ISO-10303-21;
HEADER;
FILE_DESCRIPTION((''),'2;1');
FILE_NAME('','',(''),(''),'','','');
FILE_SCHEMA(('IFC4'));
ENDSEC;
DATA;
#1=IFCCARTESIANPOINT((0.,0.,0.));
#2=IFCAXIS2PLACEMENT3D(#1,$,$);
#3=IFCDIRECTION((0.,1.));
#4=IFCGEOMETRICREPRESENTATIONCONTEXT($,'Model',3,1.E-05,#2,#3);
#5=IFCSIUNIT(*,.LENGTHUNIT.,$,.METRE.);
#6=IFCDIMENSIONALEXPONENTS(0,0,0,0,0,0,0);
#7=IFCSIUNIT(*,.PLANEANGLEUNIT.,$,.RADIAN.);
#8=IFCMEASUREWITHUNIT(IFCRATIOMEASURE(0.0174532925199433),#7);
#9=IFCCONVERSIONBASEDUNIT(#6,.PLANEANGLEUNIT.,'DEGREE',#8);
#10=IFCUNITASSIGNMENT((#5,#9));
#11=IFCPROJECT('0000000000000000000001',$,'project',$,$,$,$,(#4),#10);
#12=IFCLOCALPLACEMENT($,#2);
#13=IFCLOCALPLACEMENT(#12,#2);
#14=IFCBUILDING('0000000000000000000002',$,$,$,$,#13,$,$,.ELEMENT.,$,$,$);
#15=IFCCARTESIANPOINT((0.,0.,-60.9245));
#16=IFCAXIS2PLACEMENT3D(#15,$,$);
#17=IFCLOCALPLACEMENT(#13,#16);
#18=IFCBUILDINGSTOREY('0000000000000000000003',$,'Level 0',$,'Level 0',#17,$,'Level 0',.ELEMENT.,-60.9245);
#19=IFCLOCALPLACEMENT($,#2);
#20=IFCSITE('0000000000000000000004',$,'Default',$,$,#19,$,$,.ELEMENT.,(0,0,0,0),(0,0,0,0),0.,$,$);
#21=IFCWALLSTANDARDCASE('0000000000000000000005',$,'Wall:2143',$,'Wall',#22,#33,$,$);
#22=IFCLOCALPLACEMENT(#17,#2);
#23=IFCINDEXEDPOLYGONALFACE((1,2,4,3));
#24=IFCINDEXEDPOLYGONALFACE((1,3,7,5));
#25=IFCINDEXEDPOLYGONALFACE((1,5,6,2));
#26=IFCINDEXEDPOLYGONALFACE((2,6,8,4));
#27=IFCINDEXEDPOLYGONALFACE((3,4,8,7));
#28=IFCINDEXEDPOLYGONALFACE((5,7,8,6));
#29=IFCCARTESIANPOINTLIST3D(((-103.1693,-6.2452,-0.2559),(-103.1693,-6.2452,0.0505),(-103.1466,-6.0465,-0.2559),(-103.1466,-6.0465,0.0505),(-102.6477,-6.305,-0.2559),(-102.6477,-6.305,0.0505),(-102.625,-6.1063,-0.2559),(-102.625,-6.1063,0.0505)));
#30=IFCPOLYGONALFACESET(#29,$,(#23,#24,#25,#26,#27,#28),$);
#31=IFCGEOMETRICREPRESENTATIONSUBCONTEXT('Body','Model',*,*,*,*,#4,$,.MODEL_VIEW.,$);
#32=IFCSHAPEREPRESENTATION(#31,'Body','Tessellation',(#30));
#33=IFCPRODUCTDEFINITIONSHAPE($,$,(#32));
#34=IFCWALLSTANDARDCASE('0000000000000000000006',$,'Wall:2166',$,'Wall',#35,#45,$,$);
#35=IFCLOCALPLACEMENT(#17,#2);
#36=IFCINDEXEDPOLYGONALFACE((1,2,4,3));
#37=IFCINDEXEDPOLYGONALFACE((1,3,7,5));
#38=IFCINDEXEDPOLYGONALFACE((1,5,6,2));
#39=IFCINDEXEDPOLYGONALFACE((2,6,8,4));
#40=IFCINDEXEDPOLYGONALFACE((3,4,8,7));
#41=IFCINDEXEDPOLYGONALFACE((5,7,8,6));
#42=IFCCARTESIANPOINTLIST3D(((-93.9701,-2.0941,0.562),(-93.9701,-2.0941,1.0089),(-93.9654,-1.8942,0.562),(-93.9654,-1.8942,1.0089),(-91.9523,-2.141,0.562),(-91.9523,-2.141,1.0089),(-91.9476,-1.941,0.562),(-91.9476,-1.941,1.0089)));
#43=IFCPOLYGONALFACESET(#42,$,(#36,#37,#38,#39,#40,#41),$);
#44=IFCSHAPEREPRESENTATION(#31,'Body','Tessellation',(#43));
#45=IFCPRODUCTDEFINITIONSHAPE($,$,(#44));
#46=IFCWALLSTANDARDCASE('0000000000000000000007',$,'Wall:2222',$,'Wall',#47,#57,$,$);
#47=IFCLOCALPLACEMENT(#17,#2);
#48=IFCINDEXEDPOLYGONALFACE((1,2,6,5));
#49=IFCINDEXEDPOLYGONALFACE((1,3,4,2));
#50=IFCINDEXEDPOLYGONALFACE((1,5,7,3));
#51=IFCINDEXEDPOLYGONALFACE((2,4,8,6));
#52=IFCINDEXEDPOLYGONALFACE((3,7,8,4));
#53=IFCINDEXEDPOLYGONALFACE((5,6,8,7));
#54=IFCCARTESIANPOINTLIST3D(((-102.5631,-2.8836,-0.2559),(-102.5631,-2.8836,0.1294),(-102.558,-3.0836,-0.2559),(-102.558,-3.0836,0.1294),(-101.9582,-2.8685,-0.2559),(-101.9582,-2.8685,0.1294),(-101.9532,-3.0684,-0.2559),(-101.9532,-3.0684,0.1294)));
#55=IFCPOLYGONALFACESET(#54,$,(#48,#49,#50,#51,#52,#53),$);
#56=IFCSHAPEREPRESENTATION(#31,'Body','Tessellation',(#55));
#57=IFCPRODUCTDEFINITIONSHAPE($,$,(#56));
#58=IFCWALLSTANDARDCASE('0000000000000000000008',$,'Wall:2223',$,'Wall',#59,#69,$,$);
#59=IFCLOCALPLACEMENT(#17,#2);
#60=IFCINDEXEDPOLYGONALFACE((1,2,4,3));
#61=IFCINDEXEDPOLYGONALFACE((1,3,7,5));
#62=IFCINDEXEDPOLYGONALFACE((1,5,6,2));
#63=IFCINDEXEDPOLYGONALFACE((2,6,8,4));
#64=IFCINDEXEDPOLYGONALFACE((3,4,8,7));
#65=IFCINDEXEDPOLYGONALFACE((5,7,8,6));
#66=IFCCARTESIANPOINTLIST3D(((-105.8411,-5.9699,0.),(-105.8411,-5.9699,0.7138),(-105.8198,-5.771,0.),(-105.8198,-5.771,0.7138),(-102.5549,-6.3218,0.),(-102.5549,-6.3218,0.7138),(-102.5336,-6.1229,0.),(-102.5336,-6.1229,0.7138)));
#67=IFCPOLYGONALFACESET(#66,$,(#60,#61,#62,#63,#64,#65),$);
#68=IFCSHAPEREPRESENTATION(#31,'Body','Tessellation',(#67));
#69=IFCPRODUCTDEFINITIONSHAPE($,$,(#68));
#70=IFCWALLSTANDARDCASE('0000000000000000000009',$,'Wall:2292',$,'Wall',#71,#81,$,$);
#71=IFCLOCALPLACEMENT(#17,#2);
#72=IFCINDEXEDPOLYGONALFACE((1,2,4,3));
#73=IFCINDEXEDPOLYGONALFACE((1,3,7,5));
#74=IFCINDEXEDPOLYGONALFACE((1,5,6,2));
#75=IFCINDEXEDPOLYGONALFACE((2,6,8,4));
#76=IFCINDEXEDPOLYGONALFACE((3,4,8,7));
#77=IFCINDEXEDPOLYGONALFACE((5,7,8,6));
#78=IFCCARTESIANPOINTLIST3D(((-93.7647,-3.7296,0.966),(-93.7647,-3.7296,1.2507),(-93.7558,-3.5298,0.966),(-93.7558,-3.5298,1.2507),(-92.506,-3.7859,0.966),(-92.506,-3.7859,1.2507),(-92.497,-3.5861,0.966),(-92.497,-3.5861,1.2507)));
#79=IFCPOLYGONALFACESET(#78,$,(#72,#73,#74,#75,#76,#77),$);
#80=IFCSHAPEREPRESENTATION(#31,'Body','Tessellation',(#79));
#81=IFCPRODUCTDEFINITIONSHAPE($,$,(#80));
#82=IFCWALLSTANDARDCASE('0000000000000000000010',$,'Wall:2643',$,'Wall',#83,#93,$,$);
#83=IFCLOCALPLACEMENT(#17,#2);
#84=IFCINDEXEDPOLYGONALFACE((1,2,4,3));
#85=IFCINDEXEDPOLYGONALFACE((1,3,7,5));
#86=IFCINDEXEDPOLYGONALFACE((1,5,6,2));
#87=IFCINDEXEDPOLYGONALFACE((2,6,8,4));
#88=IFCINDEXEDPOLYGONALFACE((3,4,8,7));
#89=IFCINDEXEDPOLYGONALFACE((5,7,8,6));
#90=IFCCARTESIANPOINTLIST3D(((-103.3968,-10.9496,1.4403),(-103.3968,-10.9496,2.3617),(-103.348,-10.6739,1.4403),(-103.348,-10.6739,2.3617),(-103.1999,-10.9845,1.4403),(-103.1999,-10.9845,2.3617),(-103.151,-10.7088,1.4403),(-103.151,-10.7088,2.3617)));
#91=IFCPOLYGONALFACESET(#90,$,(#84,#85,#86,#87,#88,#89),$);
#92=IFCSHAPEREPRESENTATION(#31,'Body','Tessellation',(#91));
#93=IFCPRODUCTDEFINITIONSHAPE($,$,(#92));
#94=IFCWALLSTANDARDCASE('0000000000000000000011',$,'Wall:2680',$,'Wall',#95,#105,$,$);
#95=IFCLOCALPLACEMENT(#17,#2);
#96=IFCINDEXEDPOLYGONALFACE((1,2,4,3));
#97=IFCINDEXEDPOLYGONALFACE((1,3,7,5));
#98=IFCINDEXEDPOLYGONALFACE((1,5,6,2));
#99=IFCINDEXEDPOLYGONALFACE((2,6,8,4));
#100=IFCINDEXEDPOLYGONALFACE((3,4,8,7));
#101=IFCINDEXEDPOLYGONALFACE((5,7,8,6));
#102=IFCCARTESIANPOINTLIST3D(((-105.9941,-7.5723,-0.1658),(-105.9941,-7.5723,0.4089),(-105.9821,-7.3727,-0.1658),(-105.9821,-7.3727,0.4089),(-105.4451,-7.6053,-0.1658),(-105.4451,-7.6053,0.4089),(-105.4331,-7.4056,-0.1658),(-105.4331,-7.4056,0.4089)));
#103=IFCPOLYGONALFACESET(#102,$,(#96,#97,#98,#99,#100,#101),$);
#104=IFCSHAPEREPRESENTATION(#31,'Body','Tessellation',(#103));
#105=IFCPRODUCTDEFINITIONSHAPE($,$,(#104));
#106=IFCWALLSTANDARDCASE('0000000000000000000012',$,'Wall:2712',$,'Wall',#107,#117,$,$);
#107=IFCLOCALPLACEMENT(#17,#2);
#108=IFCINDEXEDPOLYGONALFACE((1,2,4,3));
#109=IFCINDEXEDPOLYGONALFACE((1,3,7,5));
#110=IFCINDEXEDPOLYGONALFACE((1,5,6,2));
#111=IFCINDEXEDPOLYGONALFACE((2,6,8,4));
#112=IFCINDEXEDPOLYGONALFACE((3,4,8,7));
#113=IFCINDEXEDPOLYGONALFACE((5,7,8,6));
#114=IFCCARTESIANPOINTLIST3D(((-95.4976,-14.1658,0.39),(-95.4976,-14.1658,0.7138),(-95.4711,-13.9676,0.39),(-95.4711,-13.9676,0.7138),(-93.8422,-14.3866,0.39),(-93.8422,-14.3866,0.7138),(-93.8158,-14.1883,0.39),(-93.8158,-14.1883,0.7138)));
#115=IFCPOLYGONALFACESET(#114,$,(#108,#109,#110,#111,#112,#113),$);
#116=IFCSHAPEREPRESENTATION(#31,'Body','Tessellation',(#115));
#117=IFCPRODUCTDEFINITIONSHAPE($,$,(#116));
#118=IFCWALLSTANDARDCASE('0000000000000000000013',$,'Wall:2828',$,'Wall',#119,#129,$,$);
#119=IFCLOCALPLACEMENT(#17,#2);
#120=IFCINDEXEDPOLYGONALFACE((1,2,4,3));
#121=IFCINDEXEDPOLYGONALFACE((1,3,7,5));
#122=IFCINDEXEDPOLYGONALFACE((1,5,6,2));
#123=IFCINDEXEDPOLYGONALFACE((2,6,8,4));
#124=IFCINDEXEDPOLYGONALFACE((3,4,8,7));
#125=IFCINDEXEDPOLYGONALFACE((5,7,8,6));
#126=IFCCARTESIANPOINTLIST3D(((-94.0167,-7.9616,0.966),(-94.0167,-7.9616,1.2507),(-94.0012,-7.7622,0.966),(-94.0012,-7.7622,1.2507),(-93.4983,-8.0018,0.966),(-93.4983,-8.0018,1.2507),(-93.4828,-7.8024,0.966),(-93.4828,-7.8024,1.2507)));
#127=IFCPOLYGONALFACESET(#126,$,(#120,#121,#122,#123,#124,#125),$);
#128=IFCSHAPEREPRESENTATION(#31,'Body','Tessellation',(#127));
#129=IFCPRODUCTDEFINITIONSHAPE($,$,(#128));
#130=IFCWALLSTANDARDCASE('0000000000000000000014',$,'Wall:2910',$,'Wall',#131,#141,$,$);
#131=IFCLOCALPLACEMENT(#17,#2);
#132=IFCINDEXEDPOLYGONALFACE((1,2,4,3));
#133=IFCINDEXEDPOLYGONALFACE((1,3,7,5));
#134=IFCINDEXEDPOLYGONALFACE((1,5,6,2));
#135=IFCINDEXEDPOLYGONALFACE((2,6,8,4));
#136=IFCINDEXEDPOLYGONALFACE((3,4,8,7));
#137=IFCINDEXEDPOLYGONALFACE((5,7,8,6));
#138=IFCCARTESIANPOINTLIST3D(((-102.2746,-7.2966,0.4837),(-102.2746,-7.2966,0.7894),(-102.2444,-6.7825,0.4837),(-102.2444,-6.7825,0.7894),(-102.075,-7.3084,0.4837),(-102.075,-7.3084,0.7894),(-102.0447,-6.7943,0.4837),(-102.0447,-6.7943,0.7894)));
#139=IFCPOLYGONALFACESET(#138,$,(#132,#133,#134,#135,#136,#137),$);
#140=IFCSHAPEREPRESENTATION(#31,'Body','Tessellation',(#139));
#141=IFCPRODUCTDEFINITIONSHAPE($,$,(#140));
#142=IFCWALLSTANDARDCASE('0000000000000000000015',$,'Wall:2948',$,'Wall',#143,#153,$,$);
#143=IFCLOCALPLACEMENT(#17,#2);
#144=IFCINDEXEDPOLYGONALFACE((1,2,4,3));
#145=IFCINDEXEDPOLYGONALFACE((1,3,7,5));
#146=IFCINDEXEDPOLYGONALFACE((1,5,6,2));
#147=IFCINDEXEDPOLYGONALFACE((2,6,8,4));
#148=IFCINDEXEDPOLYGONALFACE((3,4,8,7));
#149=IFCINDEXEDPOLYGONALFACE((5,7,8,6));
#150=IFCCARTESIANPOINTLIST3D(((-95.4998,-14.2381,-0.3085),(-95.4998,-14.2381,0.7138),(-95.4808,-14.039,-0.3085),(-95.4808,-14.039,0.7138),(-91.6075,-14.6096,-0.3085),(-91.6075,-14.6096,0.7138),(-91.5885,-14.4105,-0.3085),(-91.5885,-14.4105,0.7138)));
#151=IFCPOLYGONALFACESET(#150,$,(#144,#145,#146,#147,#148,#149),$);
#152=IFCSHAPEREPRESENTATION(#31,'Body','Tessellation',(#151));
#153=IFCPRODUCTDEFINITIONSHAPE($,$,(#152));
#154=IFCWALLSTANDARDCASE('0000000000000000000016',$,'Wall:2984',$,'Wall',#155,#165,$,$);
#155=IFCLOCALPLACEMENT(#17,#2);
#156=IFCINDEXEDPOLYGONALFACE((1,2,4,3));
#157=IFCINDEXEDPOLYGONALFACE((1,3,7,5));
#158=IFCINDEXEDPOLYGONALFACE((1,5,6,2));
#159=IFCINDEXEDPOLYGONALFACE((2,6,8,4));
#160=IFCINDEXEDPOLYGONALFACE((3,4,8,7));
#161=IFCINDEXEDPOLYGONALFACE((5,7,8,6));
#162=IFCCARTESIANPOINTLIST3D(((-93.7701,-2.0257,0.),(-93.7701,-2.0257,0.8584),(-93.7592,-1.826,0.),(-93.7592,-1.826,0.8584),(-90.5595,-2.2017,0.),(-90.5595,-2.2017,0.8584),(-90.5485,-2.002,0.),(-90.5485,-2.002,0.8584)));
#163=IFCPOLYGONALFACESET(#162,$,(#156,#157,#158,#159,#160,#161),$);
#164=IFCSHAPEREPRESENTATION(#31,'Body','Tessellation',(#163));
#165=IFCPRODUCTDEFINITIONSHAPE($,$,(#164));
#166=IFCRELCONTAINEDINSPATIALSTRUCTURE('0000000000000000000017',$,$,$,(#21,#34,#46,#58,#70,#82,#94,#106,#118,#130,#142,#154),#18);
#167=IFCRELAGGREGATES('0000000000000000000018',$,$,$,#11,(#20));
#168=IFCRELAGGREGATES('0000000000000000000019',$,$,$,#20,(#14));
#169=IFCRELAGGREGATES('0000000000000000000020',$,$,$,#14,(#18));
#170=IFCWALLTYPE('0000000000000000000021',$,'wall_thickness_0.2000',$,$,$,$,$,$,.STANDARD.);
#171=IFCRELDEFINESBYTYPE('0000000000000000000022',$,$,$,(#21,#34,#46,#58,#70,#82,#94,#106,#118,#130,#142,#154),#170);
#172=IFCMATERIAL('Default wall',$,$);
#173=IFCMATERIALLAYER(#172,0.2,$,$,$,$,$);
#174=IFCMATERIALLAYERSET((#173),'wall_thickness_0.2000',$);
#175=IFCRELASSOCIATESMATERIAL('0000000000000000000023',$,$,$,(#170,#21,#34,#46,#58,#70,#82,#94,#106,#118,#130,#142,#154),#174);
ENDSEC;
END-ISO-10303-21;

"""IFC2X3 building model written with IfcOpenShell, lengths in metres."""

from ifc_helpers import new_model, entity, si_unit, converted_unit, direction, frame, origin, place, context, subcontext, project, spatial, polyline, outline, extrude, material, layer, layer_set, layer_usage, type_object, element, save


model = new_model("IFC2X3")

# Units and contexts
model_context = context("Model", 3, precision=1e-05, world=origin(), true_north=direction((0.0, 1.0)))
body_context = subcontext(model_context, "Body", "Model", "MODEL_VIEW")
ifc_project = project(units=[si_unit("LENGTHUNIT", "METRE"), converted_unit("PLANEANGLEUNIT", "DEGREE", entity("IfcRatioMeasure", 0.0174532925199433), si_unit("PLANEANGLEUNIT", "RADIAN"), dimensions=[0, 0, 0, 0, 0, 0, 0])], contexts=[model_context])

# Site, building, storey
site_placement = place(None, origin())
site = spatial("IfcSite", under=ifc_project, at=site_placement, Name="Default", CompositionType="ELEMENT", RefLatitude=(0, 0, 0, 0), RefLongitude=(0, 0, 0, 0), RefElevation=0.0)
placement_1 = place(None, origin())
building_placement = place(placement_1, origin())
building = spatial("IfcBuilding", under=site, at=building_placement, CompositionType="ELEMENT")
storey_placement = place(building_placement, frame((0.0, 0.0, -60.9245)))
storey = spatial("IfcBuildingStorey", under=building, at=storey_placement, Name="Level 0", ObjectType="Level 0", LongName="Level 0", CompositionType="ELEMENT", Elevation=-60.9245)

# Walls
ifc_material = material(Name="Default wall")
ifc_layer = layer(ifc_material, 0.2)
ifc_layer_set = layer_set([ifc_layer], Name="wall_thickness_0.2000")
ifc_layer_usage = layer_usage(ifc_layer_set, "AXIS2", "POSITIVE", -0.1)
wall_type = type_object("IfcWallType", Name="wall_thickness_0.2000", PredefinedType="STANDARD", material=ifc_layer_set)
placement_2 = place(building_placement, frame((0.0, 0.0, -61.1804)))
wall_1_placement = place(placement_2, frame((-103.1579, -6.1459, 0.0), z_axis=(0.0, 0.0, 1.0), x_axis=(0.993509, -0.113756, 0.0)))
element("IfcWallStandardCase", 1, at=wall_1_placement, inside=storey, type_object=wall_type, material=ifc_layer_usage, Name="Wall:2143", ObjectType="Wall", context=body_context, shape_type="SweptSolid", body=[
    extrude(outline(polyline([(0.525, -0.1), (0.525, 0.1), (0.0, 0.1), (0.0, -0.1), (0.525, -0.1)])), origin(), (0.0, 0.0, 1.0), 0.3064),
])
placement_3 = place(building_placement, frame((0.0, 0.0, -60.3625)))
wall_2_placement = place(placement_3, frame((-93.9678, -1.9941, 0.0), z_axis=(0.0, 0.0, 1.0), x_axis=(0.99973, -0.02323, 0.0)))
element("IfcWallStandardCase", 2, at=wall_2_placement, inside=storey, type_object=wall_type, material=ifc_layer_usage, Name="Wall:2166", ObjectType="Wall", context=body_context, shape_type="SweptSolid", body=[
    extrude(outline(polyline([(2.0183, -0.1), (2.0183, 0.1), (0.0, 0.1), (0.0, -0.1), (2.0183, -0.1)])), origin(), (0.0, 0.0, 1.0), 0.447),
])
placement_4 = place(building_placement, frame((0.0, 0.0, -61.1804)))
wall_3_placement = place(placement_4, frame((-101.9557, -2.9685, 0.0), z_axis=(0.0, 0.0, 1.0), x_axis=(-0.999686, -0.025053, 0.0)))
element("IfcWallStandardCase", 3, at=wall_3_placement, inside=storey, type_object=wall_type, material=ifc_layer_usage, Name="Wall:2222", ObjectType="Wall", context=body_context, shape_type="SweptSolid", body=[
    extrude(outline(polyline([(0.605, -0.1), (0.605, 0.1), (0.0, 0.1), (0.0, -0.1), (0.605, -0.1)])), origin(), (0.0, 0.0, 1.0), 0.3853),
])
wall_4_placement = place(storey_placement, frame((-105.8305, -5.8705, 0.0), z_axis=(0.0, 0.0, 1.0), x_axis=(0.994316, -0.106473, 0.0)))
element("IfcWallStandardCase", 4, at=wall_4_placement, inside=storey, type_object=wall_type, material=ifc_layer_usage, Name="Wall:2223", ObjectType="Wall", context=body_context, shape_type="SweptSolid", body=[
    extrude(outline(polyline([(3.305, -0.1), (3.305, 0.1), (0.0, 0.1), (0.0, -0.1), (3.305, -0.1)])), origin(), (0.0, 0.0, 1.0), 0.7138),
])
placement_5 = place(building_placement, frame((0.0, 0.0, -59.9585)))
wall_5_placement = place(placement_5, frame((-93.7602, -3.6297, 0.0), z_axis=(0.0, 0.0, 1.0), x_axis=(0.999003, -0.044633, 0.0)))
element("IfcWallStandardCase", 5, at=wall_5_placement, inside=storey, type_object=wall_type, material=ifc_layer_usage, Name="Wall:2292", ObjectType="Wall", context=body_context, shape_type="SweptSolid", body=[
    extrude(outline(polyline([(1.26, -0.1), (1.26, 0.1), (0.0, 0.1), (0.0, -0.1), (1.26, -0.1)])), origin(), (0.0, 0.0, 1.0), 0.2847),
])
placement_6 = place(building_placement, frame((0.0, 0.0, -59.4842)))
wall_6_placement = place(placement_6, frame((-103.2983, -10.9671, 0.0), z_axis=(0.0, 0.0, 1.0), x_axis=(0.174386, 0.984677, 0.0)))
element("IfcWallStandardCase", 6, at=wall_6_placement, inside=storey, type_object=wall_type, material=ifc_layer_usage, Name="Wall:2643", ObjectType="Wall", context=body_context, shape_type="SweptSolid", body=[
    extrude(outline(polyline([(0.28, -0.1), (0.28, 0.1), (0.0, 0.1), (0.0, -0.1), (0.28, -0.1)])), origin(), (0.0, 0.0, 1.0), 0.9214),
])
placement_7 = place(building_placement, frame((0.0, 0.0, -61.0903)))
wall_7_placement = place(placement_7, frame((-105.4391, -7.5055, 0.0), z_axis=(0.0, 0.0, 1.0), x_axis=(-0.9982, 0.059974, 0.0)))
element("IfcWallStandardCase", 7, at=wall_7_placement, inside=storey, type_object=wall_type, material=ifc_layer_usage, Name="Wall:2680", ObjectType="Wall", context=body_context, shape_type="SweptSolid", body=[
    extrude(outline(polyline([(0.55, -0.1), (0.55, 0.1), (0.0, 0.1), (0.0, -0.1), (0.55, -0.1)])), origin(), (0.0, 0.0, 1.0), 0.5747),
])
placement_8 = place(building_placement, frame((0.0, 0.0, -60.5345)))
wall_8_placement = place(placement_8, frame((-95.4843, -14.0667, 0.0), z_axis=(0.0, 0.0, 1.0), x_axis=(0.991225, -0.132183, 0.0)))
element("IfcWallStandardCase", 8, at=wall_8_placement, inside=storey, type_object=wall_type, material=ifc_layer_usage, Name="Wall:2712", ObjectType="Wall", context=body_context, shape_type="SweptSolid", body=[
    extrude(outline(polyline([(1.67, -0.1), (1.67, 0.1), (0.0, 0.1), (0.0, -0.1), (1.67, -0.1)])), origin(), (0.0, 0.0, 1.0), 0.3237),
])
placement_9 = place(building_placement, frame((0.0, 0.0, -59.9585)))
wall_9_placement = place(placement_9, frame((-94.009, -7.8619, 0.0), z_axis=(0.0, 0.0, 1.0), x_axis=(0.997005, -0.077342, 0.0)))
element("IfcWallStandardCase", 9, at=wall_9_placement, inside=storey, type_object=wall_type, material=ifc_layer_usage, Name="Wall:2828", ObjectType="Wall", context=body_context, shape_type="SweptSolid", body=[
    extrude(outline(polyline([(0.52, -0.1), (0.52, 0.1), (0.0, 0.1), (0.0, -0.1), (0.52, -0.1)])), origin(), (0.0, 0.0, 1.0), 0.2847),
])
placement_10 = place(building_placement, frame((0.0, 0.0, -60.4408)))
wall_10_placement = place(placement_10, frame((-102.1748, -7.3025, 0.0), z_axis=(0.0, 0.0, 1.0), x_axis=(0.058813, 0.998269, 0.0)))
element("IfcWallStandardCase", 10, at=wall_10_placement, inside=storey, type_object=wall_type, material=ifc_layer_usage, Name="Wall:2910", ObjectType="Wall", context=body_context, shape_type="SweptSolid", body=[
    extrude(outline(polyline([(0.515, -0.1), (0.515, 0.1), (0.0, 0.1), (0.0, -0.1), (0.515, -0.1)])), origin(), (0.0, 0.0, 1.0), 0.3057),
])
placement_11 = place(building_placement, frame((0.0, 0.0, -61.233)))
wall_11_placement = place(placement_11, frame((-95.4903, -14.1385, 0.0), z_axis=(0.0, 0.0, 1.0), x_axis=(0.995477, -0.095008, 0.0)))
element("IfcWallStandardCase", 11, at=wall_11_placement, inside=storey, type_object=wall_type, material=ifc_layer_usage, Name="Wall:2948", ObjectType="Wall", context=body_context, shape_type="SweptSolid", body=[
    extrude(outline(polyline([(3.91, -0.1), (3.91, 0.1), (0.0, 0.1), (0.0, -0.1), (3.91, -0.1)])), origin(), (0.0, 0.0, 1.0), 1.0223),
])
wall_12_placement = place(storey_placement, frame((-93.7647, -1.9259, 0.0), z_axis=(0.0, 0.0, 1.0), x_axis=(0.998502, -0.054707, 0.0)))
element("IfcWallStandardCase", 12, at=wall_12_placement, inside=storey, type_object=wall_type, material=ifc_layer_usage, Name="Wall:2984", ObjectType="Wall", context=body_context, shape_type="SweptSolid", body=[
    extrude(outline(polyline([(3.2155, -0.1), (3.2155, 0.1), (0.0, 0.1), (0.0, -0.1), (3.2155, -0.1)])), origin(), (0.0, 0.0, 1.0), 0.8584),
])

save(model, "model.ifc")
